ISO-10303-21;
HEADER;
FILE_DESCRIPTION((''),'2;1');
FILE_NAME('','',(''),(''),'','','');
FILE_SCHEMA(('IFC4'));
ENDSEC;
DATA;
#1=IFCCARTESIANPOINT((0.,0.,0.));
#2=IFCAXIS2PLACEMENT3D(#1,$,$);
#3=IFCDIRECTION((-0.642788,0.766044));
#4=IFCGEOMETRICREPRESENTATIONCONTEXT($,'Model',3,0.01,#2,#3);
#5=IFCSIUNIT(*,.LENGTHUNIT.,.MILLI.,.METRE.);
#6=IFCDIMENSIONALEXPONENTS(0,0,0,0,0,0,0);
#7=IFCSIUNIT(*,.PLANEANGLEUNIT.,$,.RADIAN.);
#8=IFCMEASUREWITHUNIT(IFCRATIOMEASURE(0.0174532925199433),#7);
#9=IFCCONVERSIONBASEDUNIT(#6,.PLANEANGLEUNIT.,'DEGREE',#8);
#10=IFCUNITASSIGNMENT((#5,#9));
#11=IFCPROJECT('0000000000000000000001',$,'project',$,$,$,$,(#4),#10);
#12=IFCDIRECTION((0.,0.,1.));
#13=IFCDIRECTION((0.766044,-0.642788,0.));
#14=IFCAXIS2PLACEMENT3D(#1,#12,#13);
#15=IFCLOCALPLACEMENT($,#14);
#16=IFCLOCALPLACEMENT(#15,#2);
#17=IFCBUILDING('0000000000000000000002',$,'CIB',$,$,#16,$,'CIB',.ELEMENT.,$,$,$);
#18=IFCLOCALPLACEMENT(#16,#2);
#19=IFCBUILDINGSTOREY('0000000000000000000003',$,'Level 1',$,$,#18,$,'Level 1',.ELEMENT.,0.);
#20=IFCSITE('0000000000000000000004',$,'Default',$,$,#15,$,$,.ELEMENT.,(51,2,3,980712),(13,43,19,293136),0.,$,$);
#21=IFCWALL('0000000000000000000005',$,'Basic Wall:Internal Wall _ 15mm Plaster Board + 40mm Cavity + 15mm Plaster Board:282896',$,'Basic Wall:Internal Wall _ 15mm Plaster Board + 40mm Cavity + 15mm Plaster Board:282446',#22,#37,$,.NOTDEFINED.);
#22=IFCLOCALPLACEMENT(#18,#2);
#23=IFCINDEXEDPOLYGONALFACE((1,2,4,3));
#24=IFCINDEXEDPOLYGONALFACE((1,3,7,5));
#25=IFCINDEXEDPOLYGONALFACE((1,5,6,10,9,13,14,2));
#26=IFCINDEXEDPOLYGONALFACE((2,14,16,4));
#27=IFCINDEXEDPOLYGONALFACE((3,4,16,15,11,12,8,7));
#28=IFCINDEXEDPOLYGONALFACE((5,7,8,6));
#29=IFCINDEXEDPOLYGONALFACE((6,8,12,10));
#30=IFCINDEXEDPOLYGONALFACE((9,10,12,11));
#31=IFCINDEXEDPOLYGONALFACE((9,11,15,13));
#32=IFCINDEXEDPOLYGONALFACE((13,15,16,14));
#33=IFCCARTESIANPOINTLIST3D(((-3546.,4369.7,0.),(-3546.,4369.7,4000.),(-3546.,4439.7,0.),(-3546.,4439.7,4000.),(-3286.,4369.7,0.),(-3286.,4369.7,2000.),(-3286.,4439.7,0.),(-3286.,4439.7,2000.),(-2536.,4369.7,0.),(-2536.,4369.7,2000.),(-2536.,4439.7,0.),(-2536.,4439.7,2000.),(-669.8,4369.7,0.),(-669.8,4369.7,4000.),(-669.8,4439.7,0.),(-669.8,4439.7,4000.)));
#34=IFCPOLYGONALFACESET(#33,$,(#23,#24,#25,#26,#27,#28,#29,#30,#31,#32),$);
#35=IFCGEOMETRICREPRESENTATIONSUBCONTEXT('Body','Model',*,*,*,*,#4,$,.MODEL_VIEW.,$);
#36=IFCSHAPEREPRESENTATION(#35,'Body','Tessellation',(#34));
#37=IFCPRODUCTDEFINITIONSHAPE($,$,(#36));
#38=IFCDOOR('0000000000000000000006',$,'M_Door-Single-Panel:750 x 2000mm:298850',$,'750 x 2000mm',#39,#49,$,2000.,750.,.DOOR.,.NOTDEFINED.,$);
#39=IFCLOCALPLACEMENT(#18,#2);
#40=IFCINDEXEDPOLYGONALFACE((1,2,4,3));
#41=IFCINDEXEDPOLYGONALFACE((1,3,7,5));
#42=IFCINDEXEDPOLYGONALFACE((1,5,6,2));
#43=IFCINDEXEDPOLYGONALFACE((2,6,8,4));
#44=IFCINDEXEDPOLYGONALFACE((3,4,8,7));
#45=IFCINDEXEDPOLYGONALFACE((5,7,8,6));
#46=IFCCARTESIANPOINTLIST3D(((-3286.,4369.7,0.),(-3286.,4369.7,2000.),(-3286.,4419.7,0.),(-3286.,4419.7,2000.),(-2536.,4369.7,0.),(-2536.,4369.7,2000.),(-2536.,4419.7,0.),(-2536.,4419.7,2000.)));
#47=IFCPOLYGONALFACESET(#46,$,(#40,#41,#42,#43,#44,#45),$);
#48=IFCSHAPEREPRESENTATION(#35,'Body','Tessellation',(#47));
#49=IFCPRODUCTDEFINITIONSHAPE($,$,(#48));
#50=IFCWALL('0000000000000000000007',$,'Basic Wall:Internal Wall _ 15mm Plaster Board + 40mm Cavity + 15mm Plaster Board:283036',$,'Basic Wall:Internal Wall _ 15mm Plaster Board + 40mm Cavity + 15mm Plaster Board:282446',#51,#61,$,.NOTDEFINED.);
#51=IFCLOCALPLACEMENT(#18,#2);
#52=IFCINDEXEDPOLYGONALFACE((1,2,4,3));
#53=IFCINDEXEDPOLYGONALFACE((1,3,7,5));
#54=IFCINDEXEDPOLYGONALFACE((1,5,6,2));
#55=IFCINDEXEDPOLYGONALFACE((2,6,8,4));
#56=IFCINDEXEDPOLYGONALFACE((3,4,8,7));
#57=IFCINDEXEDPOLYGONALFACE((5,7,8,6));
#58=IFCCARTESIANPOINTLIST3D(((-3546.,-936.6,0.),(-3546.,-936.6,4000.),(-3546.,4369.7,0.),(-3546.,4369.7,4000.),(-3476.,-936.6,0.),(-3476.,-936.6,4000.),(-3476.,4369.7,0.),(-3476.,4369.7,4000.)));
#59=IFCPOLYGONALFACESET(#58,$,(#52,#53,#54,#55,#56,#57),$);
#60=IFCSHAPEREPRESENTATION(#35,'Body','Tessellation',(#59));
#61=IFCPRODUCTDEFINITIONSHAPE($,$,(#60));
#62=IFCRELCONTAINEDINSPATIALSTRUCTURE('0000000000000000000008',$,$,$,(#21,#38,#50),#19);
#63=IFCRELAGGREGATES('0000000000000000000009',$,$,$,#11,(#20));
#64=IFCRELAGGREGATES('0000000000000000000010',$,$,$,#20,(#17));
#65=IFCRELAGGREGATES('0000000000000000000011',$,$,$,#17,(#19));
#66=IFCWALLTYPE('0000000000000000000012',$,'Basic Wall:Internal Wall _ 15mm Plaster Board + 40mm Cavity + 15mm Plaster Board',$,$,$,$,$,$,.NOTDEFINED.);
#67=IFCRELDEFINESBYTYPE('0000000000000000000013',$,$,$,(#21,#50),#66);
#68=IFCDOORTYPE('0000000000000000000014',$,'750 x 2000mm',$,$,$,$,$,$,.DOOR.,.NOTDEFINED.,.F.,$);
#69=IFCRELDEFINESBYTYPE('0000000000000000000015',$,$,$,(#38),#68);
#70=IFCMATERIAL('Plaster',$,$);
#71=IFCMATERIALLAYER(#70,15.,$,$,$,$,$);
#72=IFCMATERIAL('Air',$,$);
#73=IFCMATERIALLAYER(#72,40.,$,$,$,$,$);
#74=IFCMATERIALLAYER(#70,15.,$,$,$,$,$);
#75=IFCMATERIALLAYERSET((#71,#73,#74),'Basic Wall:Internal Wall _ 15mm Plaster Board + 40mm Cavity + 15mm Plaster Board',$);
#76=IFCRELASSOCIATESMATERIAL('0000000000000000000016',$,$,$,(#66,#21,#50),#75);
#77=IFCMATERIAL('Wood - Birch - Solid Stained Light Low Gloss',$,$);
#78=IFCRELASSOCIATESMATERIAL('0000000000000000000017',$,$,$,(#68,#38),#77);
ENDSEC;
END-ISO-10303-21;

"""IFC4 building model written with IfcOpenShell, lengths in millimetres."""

from ifc_helpers import new_model, entity, si_unit, converted_unit, direction, frame, frame_2d, origin, origin_2d_with_axis, place, context, subcontext, project, spatial, rectangle, extrude, source, transform, mapped, material, layer, layer_set, layer_usage, type_object, type_shapes, element, fill, save


model = new_model("IFC4")

# Units and contexts
model_context = context("Model", 3, precision=0.01, world=origin(), true_north=direction((-0.642788, 0.766044)))
body_context = subcontext(model_context, "Body", "Model", "MODEL_VIEW")
ifc_project = project(units=[si_unit("LENGTHUNIT", "METRE", prefix="MILLI"), converted_unit("PLANEANGLEUNIT", "DEGREE", entity("IfcRatioMeasure", 0.0174532925199433), si_unit("PLANEANGLEUNIT", "RADIAN"), dimensions=[0, 0, 0, 0, 0, 0, 0])], contexts=[model_context])

# Site, building, storey
site_placement = place(None, frame((0.0, 0.0, 0.0), z_axis=(0.0, 0.0, 1.0), x_axis=(0.766044, -0.642788, 0.0)))
site = spatial("IfcSite", under=ifc_project, at=site_placement, Name="Default", CompositionType="ELEMENT", RefLatitude=(51, 2, 3, 980712), RefLongitude=(13, 43, 19, 293136), RefElevation=0.0)
building_placement = place(site_placement, origin())
building = spatial("IfcBuilding", under=site, at=building_placement, Name="CIB", LongName="CIB", CompositionType="ELEMENT")
storey_placement = place(building_placement, origin())
storey = spatial("IfcBuildingStorey", under=building, at=storey_placement, Name="Level 1", LongName="Level 1", CompositionType="ELEMENT", Elevation=0.0)

# Shared definitions
ifc_material_1 = material(Name="Plaster")
ifc_layer_1 = layer(ifc_material_1, 15.0)
ifc_material_2 = material(Name="Air")
ifc_layer_2 = layer(ifc_material_2, 40.0)
ifc_layer_3 = layer(ifc_material_1, 15.0)
ifc_layer_set_1 = layer_set([ifc_layer_1, ifc_layer_2, ifc_layer_3], Name="Basic Wall:Internal Wall _ 15mm Plaster Board + 40mm Cavity + 15mm Plaster Board")
wall_type_1 = type_object("IfcWallType", Name="Basic Wall:Internal Wall _ 15mm Plaster Board + 40mm Cavity + 15mm Plaster Board", PredefinedType="NOTDEFINED", material=ifc_layer_set_1)
ifc_material_3 = material(Name="Wood - Birch - Solid Stained Light Low Gloss")

# Wall, opening, door
ifc_layer_usage_1 = layer_usage(ifc_layer_set_1, "AXIS2", "NEGATIVE", 35.0)
wall_1_placement = place(storey_placement, frame((-669.8, 4404.7, 0.0), z_axis=(0.0, 0.0, 1.0), x_axis=(-1.0, 0.0, 0.0)))
wall_1 = element("IfcWall", 1, at=wall_1_placement, inside=storey, type_object=wall_type_1, material=ifc_layer_usage_1, Name="Basic Wall:Internal Wall _ 15mm Plaster Board + 40mm Cavity + 15mm Plaster Board:282896", ObjectType="Basic Wall:Internal Wall _ 15mm Plaster Board + 40mm Cavity + 15mm Plaster Board:282446", PredefinedType="NOTDEFINED", context=body_context, shape_type="SweptSolid", body=[
    extrude(rectangle(XDim=2876.2, YDim=70.0, at=frame_2d((1438.1, 0.0), x_axis=(-1.0, 0.0))), origin(), (0.0, 0.0, 1.0), 4000.0),
])
opening_1_placement = place(wall_1_placement, frame((1866.2, -35.0, 0.0)))
opening_1 = element("IfcOpeningElement", 2, at=opening_1_placement, cuts=wall_1, ObjectType="Opening", PredefinedType="OPENING", context=body_context, shape_type="SweptSolid", body=[
    extrude(rectangle(XDim=750.0, YDim=2000.0, at=frame_2d((1000.0, 375.0), x_axis=(0.0, 1.0))), frame((0.0, 0.0, 0.0), z_axis=(0.0, 1.0, 0.0), x_axis=(0.0, 0.0, 1.0)), (0.0, 0.0, 1.0), 70.0),
])
door_type_1 = type_object("IfcDoorType", Name="750 x 2000mm", OperationType="NOTDEFINED", ParameterTakesPrecedence=False, PredefinedType="DOOR", material=ifc_material_3)
shared_shape_1 = source(origin(), body_context, "Body", "SweptSolid", [
    extrude(rectangle(XDim=50.0, YDim=750.0, at=origin_2d_with_axis()), frame((375.0, 45.0, 0.0), z_axis=(0.0, 0.0, 1.0), x_axis=(0.0, 1.0, 0.0)), (0.0, 0.0, 1.0), 2000.0),
])
type_shapes(door_type_1, [shared_shape_1])
door_1_placement = place(opening_1_placement, origin())
door_1 = element("IfcDoor", 3, at=door_1_placement, inside=storey, type_object=door_type_1, material=ifc_material_3, Name="M_Door-Single-Panel:750 x 2000mm:298850", ObjectType="750 x 2000mm", OperationType="NOTDEFINED", OverallHeight=2000.0, OverallWidth=750.0, PredefinedType="DOOR", context=body_context, shape_type="MappedRepresentation", body=[
    mapped(shared_shape_1, transform((0.0, 0.0, 0.0), scale=1.0)),
])
fill(opening_1, door_1)

# Wall
ifc_layer_usage_2 = layer_usage(ifc_layer_set_1, "AXIS2", "NEGATIVE", 35.0)
wall_2_placement = place(storey_placement, frame((-3511.0, 4369.7, 0.0), z_axis=(0.0, 0.0, 1.0), x_axis=(0.0, -1.0, 0.0)))
element("IfcWall", 4, at=wall_2_placement, inside=storey, type_object=wall_type_1, material=ifc_layer_usage_2, Name="Basic Wall:Internal Wall _ 15mm Plaster Board + 40mm Cavity + 15mm Plaster Board:283036", ObjectType="Basic Wall:Internal Wall _ 15mm Plaster Board + 40mm Cavity + 15mm Plaster Board:282446", PredefinedType="NOTDEFINED", context=body_context, shape_type="SweptSolid", body=[
    extrude(rectangle(XDim=5306.2, YDim=70.0, at=frame_2d((2653.1, 0.0), x_axis=(-1.0, 0.0))), origin(), (0.0, 0.0, 1.0), 4000.0),
])

save(model, "model.ifc")
